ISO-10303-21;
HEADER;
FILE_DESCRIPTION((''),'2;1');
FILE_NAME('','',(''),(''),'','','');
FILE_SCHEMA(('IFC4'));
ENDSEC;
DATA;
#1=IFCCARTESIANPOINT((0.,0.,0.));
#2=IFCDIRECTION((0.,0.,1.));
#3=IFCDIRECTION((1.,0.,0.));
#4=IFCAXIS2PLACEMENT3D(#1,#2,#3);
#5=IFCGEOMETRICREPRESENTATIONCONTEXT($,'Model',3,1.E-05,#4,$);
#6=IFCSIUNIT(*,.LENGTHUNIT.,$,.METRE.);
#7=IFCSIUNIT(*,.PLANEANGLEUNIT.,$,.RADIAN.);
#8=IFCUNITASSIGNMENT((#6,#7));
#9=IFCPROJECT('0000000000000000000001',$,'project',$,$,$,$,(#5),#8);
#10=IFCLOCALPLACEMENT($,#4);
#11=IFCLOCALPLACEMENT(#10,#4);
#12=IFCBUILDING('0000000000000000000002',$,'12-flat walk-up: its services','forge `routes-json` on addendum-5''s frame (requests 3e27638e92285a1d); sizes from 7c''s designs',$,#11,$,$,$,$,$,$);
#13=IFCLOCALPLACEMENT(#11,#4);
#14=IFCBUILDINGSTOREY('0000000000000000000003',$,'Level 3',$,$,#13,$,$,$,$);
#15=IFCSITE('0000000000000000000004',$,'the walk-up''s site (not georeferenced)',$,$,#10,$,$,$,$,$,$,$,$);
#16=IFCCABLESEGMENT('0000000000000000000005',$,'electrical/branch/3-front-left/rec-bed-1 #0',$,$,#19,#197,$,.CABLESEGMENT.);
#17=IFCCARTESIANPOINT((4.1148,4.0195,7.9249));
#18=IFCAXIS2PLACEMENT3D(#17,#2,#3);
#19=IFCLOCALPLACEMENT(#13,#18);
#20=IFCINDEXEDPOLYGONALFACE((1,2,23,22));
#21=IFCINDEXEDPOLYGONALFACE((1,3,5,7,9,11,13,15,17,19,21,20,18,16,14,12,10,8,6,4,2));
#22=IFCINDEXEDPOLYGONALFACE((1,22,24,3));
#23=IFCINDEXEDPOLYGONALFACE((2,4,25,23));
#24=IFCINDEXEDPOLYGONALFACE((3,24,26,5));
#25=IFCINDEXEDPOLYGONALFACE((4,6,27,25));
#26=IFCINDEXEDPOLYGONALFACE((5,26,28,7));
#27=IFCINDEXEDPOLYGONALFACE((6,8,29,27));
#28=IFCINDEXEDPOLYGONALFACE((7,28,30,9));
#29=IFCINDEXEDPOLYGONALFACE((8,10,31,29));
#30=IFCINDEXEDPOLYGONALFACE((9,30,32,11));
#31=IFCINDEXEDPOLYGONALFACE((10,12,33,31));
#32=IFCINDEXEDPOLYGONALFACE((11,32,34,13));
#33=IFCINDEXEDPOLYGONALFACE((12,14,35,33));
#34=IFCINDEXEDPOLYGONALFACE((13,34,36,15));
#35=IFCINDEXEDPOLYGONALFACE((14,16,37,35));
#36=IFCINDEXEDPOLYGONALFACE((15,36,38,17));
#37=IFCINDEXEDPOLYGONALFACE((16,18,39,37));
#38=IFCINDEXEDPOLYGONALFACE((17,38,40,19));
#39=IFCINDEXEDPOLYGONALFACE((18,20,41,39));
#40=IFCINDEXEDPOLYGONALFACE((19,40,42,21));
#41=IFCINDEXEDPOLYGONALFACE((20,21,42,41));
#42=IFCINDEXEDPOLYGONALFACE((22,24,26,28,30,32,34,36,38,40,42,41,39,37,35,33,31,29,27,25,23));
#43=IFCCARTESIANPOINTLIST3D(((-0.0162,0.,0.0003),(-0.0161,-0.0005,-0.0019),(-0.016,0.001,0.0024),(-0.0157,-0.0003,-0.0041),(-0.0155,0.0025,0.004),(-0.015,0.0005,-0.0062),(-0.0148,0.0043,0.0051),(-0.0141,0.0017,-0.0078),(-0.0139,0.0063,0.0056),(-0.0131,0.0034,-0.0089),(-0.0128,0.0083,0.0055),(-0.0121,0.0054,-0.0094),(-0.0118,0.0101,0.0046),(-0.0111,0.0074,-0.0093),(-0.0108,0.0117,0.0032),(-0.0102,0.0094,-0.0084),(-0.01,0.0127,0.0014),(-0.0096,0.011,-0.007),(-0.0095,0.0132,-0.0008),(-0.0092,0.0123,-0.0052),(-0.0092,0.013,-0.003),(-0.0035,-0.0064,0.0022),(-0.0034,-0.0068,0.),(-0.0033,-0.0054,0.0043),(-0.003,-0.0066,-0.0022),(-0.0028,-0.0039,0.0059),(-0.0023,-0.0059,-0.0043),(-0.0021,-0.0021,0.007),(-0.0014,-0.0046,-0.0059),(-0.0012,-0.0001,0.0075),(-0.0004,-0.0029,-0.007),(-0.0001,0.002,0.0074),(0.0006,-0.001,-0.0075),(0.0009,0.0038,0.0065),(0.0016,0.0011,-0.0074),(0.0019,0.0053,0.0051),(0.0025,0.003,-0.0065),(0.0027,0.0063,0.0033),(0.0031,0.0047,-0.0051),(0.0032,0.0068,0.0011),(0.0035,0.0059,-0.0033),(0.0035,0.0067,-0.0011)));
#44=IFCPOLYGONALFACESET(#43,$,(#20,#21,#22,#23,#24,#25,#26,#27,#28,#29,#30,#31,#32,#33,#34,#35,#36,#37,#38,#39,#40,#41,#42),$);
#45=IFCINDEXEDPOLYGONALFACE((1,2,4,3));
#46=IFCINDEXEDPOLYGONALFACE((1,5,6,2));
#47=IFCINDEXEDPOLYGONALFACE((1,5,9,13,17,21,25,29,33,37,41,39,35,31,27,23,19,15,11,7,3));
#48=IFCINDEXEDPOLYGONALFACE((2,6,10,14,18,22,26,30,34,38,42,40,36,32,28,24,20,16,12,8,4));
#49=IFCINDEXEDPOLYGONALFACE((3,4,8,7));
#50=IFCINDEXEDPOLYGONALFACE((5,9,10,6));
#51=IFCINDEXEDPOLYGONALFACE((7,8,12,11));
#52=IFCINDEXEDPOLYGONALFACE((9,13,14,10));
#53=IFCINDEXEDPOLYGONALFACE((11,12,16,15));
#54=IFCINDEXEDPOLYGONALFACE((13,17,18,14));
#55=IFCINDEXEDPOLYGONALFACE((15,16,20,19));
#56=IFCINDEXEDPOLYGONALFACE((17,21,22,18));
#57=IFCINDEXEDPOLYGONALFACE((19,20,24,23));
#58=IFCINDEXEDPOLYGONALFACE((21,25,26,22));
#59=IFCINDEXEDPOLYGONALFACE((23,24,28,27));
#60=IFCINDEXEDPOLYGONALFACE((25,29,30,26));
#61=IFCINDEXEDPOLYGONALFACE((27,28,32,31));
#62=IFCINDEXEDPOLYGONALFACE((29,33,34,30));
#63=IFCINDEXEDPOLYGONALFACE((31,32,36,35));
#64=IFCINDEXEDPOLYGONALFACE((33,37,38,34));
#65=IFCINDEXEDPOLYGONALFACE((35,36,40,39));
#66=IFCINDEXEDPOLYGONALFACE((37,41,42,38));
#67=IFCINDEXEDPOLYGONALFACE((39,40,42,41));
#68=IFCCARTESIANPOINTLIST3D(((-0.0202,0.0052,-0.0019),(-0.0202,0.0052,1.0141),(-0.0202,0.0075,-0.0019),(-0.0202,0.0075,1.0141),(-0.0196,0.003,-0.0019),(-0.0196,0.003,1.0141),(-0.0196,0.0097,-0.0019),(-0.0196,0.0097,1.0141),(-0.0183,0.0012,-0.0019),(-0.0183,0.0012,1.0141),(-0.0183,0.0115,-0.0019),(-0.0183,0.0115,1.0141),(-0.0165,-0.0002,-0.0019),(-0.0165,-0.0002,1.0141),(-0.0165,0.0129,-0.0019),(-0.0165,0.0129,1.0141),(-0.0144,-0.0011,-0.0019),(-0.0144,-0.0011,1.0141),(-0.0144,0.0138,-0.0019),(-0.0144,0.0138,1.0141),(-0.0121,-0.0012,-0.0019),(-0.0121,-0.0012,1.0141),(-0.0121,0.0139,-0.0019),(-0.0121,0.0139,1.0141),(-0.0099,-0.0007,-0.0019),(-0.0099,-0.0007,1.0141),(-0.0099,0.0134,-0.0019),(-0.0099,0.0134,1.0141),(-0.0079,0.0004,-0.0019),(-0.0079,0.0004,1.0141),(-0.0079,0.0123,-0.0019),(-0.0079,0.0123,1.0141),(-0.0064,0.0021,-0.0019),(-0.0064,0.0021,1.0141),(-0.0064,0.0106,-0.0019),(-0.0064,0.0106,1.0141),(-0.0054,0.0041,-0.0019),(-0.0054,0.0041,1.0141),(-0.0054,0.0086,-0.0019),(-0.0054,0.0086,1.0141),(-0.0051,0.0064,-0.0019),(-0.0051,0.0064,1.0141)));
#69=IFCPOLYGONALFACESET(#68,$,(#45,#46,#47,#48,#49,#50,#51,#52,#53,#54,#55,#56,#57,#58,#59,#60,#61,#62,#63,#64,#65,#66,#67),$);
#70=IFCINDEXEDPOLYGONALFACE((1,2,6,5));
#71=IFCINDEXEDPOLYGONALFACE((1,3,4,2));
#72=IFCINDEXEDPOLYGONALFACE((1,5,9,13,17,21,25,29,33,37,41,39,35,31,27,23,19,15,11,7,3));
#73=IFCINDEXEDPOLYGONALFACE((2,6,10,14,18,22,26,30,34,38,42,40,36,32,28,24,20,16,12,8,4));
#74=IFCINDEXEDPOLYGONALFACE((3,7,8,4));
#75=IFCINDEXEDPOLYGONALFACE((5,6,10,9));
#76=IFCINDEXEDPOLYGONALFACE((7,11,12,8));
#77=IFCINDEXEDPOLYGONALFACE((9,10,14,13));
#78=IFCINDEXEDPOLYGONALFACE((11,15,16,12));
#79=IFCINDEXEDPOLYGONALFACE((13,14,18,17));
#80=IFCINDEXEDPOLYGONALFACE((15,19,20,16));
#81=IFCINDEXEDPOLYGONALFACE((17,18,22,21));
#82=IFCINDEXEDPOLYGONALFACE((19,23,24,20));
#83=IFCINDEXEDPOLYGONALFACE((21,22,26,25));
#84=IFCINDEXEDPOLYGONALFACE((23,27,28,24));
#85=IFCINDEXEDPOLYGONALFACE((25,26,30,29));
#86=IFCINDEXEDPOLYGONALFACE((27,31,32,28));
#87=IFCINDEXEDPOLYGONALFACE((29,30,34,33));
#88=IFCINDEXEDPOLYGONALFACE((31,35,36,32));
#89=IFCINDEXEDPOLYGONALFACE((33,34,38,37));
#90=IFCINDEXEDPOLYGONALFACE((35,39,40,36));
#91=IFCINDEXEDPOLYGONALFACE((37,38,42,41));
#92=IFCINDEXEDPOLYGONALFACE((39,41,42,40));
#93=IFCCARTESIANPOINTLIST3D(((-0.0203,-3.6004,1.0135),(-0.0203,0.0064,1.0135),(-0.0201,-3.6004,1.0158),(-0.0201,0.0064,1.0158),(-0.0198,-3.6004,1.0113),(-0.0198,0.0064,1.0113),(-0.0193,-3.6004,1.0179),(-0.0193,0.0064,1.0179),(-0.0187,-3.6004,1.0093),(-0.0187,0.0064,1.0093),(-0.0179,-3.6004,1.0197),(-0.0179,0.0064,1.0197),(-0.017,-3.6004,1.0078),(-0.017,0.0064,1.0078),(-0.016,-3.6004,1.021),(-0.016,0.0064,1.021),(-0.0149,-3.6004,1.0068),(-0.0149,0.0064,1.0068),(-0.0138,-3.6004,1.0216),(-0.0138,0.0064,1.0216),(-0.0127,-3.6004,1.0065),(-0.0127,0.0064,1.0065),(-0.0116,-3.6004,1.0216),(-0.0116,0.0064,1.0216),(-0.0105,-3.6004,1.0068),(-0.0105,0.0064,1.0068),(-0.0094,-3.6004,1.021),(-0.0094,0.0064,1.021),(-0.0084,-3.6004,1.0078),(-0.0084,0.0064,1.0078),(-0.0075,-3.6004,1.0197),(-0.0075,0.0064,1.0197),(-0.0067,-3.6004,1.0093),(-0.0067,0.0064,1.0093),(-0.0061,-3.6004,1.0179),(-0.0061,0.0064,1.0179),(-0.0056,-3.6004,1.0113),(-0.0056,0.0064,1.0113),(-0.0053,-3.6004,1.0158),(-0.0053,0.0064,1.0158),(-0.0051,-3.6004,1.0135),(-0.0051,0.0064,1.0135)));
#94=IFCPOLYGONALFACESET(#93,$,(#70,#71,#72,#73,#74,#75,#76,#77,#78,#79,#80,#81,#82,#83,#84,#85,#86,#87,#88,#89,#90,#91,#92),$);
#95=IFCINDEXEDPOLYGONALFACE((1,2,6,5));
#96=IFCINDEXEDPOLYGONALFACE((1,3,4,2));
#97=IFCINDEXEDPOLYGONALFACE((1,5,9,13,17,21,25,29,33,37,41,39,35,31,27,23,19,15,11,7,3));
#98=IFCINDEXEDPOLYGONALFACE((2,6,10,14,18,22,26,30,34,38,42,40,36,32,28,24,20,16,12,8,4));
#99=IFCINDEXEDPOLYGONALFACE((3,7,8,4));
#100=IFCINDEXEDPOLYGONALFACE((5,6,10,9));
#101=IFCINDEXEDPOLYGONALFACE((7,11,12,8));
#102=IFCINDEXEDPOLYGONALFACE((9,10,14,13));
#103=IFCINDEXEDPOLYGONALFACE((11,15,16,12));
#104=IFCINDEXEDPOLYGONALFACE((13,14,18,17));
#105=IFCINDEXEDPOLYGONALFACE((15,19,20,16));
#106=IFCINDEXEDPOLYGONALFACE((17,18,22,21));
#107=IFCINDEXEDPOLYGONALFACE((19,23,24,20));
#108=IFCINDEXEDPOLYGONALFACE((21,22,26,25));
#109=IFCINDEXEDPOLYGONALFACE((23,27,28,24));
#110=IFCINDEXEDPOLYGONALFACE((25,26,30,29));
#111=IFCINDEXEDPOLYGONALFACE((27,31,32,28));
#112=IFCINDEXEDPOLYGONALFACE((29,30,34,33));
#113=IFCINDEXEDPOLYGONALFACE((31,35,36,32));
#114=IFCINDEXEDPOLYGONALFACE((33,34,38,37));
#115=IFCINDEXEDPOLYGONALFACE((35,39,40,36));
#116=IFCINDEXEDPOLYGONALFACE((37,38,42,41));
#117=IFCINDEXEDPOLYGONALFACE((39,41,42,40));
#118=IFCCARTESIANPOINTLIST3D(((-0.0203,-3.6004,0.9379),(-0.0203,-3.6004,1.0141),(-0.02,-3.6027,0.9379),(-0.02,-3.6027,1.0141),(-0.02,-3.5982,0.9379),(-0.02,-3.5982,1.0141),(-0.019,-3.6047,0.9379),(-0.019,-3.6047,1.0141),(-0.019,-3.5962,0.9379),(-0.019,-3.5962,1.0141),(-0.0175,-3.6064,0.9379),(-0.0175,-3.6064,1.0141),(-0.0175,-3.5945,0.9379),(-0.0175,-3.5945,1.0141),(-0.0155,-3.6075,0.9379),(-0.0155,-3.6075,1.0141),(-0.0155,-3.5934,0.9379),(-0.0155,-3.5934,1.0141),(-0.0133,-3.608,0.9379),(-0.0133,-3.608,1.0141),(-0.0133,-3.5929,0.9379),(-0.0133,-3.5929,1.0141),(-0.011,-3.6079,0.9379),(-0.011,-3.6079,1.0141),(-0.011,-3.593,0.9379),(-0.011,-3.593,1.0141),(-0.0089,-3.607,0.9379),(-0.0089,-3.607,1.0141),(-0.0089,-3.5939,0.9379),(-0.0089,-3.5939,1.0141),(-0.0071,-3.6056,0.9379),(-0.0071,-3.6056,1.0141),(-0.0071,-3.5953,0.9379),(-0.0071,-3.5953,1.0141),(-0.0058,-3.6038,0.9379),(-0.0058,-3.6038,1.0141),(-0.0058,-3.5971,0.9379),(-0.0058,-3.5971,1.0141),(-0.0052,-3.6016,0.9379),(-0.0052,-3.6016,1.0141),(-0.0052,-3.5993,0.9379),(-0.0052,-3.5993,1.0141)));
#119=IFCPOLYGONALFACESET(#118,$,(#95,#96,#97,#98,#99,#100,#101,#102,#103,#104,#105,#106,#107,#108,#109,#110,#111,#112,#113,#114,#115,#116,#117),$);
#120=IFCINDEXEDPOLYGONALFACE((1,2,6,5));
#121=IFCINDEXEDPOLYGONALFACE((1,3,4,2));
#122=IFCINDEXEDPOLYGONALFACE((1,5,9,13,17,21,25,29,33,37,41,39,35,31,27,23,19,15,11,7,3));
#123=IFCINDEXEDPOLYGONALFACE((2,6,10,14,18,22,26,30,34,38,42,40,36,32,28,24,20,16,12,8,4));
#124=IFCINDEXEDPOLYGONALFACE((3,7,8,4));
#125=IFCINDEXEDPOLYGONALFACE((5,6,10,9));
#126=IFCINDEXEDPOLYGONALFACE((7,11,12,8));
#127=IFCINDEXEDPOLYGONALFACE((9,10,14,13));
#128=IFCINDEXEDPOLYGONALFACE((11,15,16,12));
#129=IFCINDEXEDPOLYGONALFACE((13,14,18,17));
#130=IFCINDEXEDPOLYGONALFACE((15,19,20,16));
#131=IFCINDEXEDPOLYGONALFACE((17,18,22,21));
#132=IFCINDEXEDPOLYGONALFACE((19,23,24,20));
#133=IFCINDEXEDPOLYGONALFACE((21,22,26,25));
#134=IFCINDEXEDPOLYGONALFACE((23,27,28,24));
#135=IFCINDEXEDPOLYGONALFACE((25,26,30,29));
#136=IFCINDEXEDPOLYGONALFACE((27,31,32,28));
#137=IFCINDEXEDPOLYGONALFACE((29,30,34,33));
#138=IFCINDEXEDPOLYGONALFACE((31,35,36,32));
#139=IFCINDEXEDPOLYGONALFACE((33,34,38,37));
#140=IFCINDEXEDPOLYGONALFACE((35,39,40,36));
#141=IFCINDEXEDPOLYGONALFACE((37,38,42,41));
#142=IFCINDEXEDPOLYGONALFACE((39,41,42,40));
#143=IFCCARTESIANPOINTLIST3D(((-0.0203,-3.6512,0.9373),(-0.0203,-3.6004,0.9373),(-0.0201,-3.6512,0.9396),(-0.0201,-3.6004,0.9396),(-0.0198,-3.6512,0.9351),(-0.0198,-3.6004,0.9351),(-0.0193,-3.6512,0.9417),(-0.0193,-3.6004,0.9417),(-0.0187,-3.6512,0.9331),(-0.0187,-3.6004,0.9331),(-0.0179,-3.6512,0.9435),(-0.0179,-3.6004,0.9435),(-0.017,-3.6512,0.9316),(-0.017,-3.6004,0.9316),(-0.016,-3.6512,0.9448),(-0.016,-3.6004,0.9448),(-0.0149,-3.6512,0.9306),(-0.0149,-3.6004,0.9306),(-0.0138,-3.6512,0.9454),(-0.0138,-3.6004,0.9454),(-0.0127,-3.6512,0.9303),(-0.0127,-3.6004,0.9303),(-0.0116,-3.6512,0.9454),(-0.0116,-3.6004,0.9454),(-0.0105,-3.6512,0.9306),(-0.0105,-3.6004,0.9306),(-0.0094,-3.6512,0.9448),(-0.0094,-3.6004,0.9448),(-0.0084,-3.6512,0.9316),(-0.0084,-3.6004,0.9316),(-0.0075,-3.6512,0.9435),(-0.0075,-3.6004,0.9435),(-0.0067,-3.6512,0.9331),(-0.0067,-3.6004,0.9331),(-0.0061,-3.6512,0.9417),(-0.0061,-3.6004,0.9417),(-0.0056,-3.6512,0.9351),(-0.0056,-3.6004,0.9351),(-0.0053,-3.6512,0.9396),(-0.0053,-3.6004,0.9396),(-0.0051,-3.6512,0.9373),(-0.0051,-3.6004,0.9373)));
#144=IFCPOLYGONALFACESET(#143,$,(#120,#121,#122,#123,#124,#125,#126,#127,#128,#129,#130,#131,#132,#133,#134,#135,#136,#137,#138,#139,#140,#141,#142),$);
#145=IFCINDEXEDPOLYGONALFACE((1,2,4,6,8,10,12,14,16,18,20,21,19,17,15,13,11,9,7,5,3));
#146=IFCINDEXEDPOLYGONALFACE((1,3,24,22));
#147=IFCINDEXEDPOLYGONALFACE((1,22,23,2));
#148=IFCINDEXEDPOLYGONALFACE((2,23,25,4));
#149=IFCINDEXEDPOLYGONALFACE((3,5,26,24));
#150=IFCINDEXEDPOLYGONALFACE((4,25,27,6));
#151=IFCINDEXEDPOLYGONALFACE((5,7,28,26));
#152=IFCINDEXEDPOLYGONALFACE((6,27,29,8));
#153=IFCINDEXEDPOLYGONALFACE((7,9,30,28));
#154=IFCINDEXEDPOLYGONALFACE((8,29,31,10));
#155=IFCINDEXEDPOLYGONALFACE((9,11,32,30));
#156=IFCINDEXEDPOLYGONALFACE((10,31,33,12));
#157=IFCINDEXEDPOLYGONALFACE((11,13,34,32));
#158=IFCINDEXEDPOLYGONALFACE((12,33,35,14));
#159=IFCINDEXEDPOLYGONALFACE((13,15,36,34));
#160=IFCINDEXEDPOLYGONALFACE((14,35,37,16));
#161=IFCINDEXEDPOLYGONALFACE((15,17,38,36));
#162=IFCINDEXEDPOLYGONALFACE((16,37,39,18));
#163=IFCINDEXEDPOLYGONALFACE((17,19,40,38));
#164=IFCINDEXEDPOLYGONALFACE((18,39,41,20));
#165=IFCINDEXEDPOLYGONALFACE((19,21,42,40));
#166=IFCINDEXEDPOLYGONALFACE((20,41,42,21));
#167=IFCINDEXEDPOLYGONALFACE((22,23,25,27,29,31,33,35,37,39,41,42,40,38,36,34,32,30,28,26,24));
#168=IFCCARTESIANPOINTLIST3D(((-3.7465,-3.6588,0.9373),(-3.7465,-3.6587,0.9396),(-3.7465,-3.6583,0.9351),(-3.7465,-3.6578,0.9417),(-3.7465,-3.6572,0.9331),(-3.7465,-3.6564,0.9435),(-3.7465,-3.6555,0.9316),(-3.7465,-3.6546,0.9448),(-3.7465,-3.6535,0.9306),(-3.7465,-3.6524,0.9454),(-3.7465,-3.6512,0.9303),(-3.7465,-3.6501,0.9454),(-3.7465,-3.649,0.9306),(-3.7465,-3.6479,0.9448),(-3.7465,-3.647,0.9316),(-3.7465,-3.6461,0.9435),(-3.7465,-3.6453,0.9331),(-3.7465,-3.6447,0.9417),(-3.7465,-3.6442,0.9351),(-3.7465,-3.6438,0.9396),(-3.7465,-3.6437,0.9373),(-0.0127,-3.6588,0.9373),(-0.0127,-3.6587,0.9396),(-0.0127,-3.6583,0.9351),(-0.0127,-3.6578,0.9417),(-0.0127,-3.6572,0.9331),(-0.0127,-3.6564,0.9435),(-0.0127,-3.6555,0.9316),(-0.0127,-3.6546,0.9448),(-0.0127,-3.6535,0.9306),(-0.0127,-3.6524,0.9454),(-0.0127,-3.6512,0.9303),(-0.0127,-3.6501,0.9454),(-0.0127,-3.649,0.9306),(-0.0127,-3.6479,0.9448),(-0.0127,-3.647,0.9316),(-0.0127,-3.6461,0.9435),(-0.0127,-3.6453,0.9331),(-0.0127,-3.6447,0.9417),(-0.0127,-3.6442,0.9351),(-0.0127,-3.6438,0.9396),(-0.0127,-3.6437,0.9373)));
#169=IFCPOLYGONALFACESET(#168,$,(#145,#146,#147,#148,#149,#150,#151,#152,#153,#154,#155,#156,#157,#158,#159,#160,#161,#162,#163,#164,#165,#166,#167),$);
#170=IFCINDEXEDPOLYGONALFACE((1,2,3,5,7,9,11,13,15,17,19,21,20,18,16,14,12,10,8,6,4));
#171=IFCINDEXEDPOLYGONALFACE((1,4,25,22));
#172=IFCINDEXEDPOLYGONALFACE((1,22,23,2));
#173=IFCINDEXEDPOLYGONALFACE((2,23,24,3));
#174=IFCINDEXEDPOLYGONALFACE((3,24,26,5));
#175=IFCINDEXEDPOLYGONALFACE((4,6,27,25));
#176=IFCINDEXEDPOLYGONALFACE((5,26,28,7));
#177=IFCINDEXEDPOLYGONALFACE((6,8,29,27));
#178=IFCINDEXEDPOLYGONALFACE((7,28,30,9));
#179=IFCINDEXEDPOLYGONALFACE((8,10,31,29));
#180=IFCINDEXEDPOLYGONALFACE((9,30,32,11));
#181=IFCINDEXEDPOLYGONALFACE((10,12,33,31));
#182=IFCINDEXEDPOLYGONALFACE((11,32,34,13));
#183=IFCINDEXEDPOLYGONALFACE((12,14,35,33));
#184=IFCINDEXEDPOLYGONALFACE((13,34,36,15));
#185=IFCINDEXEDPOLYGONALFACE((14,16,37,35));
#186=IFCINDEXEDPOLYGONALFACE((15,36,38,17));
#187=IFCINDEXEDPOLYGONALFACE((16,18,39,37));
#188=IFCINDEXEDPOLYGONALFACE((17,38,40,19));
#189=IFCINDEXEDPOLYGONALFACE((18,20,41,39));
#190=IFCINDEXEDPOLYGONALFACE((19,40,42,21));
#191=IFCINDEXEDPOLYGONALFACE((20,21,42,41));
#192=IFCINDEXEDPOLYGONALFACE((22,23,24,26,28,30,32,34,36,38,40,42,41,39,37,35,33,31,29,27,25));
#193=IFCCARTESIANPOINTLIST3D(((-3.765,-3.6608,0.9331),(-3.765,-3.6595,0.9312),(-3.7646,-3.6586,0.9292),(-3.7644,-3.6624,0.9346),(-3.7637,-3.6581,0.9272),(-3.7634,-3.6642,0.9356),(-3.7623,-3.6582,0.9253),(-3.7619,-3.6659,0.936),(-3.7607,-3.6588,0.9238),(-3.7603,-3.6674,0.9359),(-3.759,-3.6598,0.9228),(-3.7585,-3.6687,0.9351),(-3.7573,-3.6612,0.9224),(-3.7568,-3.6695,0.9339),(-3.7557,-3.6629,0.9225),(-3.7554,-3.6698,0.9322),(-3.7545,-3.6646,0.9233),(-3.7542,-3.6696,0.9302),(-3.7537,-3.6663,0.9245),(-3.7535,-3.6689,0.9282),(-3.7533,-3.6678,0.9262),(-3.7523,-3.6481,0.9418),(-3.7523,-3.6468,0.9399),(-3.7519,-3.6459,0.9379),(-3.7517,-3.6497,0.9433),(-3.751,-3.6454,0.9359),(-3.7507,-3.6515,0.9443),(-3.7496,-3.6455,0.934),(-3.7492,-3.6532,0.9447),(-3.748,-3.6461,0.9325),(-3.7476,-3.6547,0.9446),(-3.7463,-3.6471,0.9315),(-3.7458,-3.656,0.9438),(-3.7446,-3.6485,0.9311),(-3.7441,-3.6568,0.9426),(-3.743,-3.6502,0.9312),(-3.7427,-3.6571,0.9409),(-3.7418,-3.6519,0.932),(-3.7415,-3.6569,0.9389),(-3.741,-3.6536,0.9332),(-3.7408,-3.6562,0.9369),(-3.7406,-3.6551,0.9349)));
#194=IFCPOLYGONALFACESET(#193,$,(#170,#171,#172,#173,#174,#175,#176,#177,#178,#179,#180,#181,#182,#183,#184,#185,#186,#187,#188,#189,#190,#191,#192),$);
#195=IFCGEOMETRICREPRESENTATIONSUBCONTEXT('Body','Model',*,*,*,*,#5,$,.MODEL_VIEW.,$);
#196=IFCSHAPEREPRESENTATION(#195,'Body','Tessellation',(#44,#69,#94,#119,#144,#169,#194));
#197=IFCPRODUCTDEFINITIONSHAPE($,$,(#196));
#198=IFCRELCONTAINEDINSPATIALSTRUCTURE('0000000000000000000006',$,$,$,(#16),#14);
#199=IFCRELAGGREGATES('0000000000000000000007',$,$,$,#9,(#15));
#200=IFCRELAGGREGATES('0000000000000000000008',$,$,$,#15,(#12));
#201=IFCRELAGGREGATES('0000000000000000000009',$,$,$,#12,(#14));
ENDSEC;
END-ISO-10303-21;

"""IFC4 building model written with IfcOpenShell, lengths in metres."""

from ifc_helpers import new_model, entity, si_unit, frame, origin_with_axes, place, context, subcontext, project, spatial, element, save


model = new_model("IFC4")

# Units and contexts
model_context = context("Model", 3, precision=1e-05, world=origin_with_axes())
body_context = subcontext(model_context, "Body", "Model", "MODEL_VIEW")
ifc_project = project(units=[si_unit("LENGTHUNIT", "METRE"), si_unit("PLANEANGLEUNIT", "RADIAN")], contexts=[model_context])

# Site, building, storey
site_placement = place(None, origin_with_axes())
site = spatial("IfcSite", under=ifc_project, at=site_placement, Name="the walk-up's site (not georeferenced)")
building_placement = place(site_placement, origin_with_axes())
building = spatial("IfcBuilding", under=site, at=building_placement, Name="12-flat walk-up: its services", Description="forge `routes-json` on addendum-5's frame (requests 3e27638e92285a1d); sizes from 7c's designs")
storey_placement = place(building_placement, origin_with_axes())
storey = spatial("IfcBuildingStorey", under=building, at=storey_placement, Name="Level 3")

# Cable segment
cable_segment_1_placement = place(storey_placement, frame((4.1148, 4.0195, 7.9249), z_axis=(0.0, 0.0, 1.0), x_axis=(1.0, 0.0, 0.0)))
element("IfcCableSegment", 1, at=cable_segment_1_placement, inside=storey, Name="electrical/branch/3-front-left/rec-bed-1 #0", PredefinedType="CABLESEGMENT", context=body_context, shape_type="AdvancedSweptSolid", body=[
    entity("IfcSweptDiskSolid", entity("IfcPolyline", [entity("IfcCartesianPoint", [0.0, 0.0, 0.0]), entity("IfcCartesianPoint", [-0.0127, 0.0064, -0.0019])]), 0.0076),
    entity("IfcSweptDiskSolid", entity("IfcPolyline", [entity("IfcCartesianPoint", [-0.0127, 0.0064, -0.0019]), entity("IfcCartesianPoint", [-0.0127, 0.0064, 1.0141])]), 0.0076),
    entity("IfcSweptDiskSolid", entity("IfcPolyline", [entity("IfcCartesianPoint", [-0.0127, 0.0064, 1.0141]), entity("IfcCartesianPoint", [-0.0127, -3.6004, 1.0141])]), 0.0076),
    entity("IfcSweptDiskSolid", entity("IfcPolyline", [entity("IfcCartesianPoint", [-0.0127, -3.6004, 1.0141]), entity("IfcCartesianPoint", [-0.0127, -3.6004, 0.9379])]), 0.0076),
    entity("IfcSweptDiskSolid", entity("IfcPolyline", [entity("IfcCartesianPoint", [-0.0127, -3.6004, 0.9379]), entity("IfcCartesianPoint", [-0.0127, -3.6512, 0.9379])]), 0.0076),
    entity("IfcSweptDiskSolid", entity("IfcPolyline", [entity("IfcCartesianPoint", [-0.0127, -3.6512, 0.9379]), entity("IfcCartesianPoint", [-3.7465, -3.6512, 0.9379])]), 0.0076),
    entity("IfcSweptDiskSolid", entity("IfcPolyline", [entity("IfcCartesianPoint", [-3.7465, -3.6512, 0.9379]), entity("IfcCartesianPoint", [-3.7592, -3.6639, 0.9292])]), 0.0076),
])

save(model, "model.ifc")
